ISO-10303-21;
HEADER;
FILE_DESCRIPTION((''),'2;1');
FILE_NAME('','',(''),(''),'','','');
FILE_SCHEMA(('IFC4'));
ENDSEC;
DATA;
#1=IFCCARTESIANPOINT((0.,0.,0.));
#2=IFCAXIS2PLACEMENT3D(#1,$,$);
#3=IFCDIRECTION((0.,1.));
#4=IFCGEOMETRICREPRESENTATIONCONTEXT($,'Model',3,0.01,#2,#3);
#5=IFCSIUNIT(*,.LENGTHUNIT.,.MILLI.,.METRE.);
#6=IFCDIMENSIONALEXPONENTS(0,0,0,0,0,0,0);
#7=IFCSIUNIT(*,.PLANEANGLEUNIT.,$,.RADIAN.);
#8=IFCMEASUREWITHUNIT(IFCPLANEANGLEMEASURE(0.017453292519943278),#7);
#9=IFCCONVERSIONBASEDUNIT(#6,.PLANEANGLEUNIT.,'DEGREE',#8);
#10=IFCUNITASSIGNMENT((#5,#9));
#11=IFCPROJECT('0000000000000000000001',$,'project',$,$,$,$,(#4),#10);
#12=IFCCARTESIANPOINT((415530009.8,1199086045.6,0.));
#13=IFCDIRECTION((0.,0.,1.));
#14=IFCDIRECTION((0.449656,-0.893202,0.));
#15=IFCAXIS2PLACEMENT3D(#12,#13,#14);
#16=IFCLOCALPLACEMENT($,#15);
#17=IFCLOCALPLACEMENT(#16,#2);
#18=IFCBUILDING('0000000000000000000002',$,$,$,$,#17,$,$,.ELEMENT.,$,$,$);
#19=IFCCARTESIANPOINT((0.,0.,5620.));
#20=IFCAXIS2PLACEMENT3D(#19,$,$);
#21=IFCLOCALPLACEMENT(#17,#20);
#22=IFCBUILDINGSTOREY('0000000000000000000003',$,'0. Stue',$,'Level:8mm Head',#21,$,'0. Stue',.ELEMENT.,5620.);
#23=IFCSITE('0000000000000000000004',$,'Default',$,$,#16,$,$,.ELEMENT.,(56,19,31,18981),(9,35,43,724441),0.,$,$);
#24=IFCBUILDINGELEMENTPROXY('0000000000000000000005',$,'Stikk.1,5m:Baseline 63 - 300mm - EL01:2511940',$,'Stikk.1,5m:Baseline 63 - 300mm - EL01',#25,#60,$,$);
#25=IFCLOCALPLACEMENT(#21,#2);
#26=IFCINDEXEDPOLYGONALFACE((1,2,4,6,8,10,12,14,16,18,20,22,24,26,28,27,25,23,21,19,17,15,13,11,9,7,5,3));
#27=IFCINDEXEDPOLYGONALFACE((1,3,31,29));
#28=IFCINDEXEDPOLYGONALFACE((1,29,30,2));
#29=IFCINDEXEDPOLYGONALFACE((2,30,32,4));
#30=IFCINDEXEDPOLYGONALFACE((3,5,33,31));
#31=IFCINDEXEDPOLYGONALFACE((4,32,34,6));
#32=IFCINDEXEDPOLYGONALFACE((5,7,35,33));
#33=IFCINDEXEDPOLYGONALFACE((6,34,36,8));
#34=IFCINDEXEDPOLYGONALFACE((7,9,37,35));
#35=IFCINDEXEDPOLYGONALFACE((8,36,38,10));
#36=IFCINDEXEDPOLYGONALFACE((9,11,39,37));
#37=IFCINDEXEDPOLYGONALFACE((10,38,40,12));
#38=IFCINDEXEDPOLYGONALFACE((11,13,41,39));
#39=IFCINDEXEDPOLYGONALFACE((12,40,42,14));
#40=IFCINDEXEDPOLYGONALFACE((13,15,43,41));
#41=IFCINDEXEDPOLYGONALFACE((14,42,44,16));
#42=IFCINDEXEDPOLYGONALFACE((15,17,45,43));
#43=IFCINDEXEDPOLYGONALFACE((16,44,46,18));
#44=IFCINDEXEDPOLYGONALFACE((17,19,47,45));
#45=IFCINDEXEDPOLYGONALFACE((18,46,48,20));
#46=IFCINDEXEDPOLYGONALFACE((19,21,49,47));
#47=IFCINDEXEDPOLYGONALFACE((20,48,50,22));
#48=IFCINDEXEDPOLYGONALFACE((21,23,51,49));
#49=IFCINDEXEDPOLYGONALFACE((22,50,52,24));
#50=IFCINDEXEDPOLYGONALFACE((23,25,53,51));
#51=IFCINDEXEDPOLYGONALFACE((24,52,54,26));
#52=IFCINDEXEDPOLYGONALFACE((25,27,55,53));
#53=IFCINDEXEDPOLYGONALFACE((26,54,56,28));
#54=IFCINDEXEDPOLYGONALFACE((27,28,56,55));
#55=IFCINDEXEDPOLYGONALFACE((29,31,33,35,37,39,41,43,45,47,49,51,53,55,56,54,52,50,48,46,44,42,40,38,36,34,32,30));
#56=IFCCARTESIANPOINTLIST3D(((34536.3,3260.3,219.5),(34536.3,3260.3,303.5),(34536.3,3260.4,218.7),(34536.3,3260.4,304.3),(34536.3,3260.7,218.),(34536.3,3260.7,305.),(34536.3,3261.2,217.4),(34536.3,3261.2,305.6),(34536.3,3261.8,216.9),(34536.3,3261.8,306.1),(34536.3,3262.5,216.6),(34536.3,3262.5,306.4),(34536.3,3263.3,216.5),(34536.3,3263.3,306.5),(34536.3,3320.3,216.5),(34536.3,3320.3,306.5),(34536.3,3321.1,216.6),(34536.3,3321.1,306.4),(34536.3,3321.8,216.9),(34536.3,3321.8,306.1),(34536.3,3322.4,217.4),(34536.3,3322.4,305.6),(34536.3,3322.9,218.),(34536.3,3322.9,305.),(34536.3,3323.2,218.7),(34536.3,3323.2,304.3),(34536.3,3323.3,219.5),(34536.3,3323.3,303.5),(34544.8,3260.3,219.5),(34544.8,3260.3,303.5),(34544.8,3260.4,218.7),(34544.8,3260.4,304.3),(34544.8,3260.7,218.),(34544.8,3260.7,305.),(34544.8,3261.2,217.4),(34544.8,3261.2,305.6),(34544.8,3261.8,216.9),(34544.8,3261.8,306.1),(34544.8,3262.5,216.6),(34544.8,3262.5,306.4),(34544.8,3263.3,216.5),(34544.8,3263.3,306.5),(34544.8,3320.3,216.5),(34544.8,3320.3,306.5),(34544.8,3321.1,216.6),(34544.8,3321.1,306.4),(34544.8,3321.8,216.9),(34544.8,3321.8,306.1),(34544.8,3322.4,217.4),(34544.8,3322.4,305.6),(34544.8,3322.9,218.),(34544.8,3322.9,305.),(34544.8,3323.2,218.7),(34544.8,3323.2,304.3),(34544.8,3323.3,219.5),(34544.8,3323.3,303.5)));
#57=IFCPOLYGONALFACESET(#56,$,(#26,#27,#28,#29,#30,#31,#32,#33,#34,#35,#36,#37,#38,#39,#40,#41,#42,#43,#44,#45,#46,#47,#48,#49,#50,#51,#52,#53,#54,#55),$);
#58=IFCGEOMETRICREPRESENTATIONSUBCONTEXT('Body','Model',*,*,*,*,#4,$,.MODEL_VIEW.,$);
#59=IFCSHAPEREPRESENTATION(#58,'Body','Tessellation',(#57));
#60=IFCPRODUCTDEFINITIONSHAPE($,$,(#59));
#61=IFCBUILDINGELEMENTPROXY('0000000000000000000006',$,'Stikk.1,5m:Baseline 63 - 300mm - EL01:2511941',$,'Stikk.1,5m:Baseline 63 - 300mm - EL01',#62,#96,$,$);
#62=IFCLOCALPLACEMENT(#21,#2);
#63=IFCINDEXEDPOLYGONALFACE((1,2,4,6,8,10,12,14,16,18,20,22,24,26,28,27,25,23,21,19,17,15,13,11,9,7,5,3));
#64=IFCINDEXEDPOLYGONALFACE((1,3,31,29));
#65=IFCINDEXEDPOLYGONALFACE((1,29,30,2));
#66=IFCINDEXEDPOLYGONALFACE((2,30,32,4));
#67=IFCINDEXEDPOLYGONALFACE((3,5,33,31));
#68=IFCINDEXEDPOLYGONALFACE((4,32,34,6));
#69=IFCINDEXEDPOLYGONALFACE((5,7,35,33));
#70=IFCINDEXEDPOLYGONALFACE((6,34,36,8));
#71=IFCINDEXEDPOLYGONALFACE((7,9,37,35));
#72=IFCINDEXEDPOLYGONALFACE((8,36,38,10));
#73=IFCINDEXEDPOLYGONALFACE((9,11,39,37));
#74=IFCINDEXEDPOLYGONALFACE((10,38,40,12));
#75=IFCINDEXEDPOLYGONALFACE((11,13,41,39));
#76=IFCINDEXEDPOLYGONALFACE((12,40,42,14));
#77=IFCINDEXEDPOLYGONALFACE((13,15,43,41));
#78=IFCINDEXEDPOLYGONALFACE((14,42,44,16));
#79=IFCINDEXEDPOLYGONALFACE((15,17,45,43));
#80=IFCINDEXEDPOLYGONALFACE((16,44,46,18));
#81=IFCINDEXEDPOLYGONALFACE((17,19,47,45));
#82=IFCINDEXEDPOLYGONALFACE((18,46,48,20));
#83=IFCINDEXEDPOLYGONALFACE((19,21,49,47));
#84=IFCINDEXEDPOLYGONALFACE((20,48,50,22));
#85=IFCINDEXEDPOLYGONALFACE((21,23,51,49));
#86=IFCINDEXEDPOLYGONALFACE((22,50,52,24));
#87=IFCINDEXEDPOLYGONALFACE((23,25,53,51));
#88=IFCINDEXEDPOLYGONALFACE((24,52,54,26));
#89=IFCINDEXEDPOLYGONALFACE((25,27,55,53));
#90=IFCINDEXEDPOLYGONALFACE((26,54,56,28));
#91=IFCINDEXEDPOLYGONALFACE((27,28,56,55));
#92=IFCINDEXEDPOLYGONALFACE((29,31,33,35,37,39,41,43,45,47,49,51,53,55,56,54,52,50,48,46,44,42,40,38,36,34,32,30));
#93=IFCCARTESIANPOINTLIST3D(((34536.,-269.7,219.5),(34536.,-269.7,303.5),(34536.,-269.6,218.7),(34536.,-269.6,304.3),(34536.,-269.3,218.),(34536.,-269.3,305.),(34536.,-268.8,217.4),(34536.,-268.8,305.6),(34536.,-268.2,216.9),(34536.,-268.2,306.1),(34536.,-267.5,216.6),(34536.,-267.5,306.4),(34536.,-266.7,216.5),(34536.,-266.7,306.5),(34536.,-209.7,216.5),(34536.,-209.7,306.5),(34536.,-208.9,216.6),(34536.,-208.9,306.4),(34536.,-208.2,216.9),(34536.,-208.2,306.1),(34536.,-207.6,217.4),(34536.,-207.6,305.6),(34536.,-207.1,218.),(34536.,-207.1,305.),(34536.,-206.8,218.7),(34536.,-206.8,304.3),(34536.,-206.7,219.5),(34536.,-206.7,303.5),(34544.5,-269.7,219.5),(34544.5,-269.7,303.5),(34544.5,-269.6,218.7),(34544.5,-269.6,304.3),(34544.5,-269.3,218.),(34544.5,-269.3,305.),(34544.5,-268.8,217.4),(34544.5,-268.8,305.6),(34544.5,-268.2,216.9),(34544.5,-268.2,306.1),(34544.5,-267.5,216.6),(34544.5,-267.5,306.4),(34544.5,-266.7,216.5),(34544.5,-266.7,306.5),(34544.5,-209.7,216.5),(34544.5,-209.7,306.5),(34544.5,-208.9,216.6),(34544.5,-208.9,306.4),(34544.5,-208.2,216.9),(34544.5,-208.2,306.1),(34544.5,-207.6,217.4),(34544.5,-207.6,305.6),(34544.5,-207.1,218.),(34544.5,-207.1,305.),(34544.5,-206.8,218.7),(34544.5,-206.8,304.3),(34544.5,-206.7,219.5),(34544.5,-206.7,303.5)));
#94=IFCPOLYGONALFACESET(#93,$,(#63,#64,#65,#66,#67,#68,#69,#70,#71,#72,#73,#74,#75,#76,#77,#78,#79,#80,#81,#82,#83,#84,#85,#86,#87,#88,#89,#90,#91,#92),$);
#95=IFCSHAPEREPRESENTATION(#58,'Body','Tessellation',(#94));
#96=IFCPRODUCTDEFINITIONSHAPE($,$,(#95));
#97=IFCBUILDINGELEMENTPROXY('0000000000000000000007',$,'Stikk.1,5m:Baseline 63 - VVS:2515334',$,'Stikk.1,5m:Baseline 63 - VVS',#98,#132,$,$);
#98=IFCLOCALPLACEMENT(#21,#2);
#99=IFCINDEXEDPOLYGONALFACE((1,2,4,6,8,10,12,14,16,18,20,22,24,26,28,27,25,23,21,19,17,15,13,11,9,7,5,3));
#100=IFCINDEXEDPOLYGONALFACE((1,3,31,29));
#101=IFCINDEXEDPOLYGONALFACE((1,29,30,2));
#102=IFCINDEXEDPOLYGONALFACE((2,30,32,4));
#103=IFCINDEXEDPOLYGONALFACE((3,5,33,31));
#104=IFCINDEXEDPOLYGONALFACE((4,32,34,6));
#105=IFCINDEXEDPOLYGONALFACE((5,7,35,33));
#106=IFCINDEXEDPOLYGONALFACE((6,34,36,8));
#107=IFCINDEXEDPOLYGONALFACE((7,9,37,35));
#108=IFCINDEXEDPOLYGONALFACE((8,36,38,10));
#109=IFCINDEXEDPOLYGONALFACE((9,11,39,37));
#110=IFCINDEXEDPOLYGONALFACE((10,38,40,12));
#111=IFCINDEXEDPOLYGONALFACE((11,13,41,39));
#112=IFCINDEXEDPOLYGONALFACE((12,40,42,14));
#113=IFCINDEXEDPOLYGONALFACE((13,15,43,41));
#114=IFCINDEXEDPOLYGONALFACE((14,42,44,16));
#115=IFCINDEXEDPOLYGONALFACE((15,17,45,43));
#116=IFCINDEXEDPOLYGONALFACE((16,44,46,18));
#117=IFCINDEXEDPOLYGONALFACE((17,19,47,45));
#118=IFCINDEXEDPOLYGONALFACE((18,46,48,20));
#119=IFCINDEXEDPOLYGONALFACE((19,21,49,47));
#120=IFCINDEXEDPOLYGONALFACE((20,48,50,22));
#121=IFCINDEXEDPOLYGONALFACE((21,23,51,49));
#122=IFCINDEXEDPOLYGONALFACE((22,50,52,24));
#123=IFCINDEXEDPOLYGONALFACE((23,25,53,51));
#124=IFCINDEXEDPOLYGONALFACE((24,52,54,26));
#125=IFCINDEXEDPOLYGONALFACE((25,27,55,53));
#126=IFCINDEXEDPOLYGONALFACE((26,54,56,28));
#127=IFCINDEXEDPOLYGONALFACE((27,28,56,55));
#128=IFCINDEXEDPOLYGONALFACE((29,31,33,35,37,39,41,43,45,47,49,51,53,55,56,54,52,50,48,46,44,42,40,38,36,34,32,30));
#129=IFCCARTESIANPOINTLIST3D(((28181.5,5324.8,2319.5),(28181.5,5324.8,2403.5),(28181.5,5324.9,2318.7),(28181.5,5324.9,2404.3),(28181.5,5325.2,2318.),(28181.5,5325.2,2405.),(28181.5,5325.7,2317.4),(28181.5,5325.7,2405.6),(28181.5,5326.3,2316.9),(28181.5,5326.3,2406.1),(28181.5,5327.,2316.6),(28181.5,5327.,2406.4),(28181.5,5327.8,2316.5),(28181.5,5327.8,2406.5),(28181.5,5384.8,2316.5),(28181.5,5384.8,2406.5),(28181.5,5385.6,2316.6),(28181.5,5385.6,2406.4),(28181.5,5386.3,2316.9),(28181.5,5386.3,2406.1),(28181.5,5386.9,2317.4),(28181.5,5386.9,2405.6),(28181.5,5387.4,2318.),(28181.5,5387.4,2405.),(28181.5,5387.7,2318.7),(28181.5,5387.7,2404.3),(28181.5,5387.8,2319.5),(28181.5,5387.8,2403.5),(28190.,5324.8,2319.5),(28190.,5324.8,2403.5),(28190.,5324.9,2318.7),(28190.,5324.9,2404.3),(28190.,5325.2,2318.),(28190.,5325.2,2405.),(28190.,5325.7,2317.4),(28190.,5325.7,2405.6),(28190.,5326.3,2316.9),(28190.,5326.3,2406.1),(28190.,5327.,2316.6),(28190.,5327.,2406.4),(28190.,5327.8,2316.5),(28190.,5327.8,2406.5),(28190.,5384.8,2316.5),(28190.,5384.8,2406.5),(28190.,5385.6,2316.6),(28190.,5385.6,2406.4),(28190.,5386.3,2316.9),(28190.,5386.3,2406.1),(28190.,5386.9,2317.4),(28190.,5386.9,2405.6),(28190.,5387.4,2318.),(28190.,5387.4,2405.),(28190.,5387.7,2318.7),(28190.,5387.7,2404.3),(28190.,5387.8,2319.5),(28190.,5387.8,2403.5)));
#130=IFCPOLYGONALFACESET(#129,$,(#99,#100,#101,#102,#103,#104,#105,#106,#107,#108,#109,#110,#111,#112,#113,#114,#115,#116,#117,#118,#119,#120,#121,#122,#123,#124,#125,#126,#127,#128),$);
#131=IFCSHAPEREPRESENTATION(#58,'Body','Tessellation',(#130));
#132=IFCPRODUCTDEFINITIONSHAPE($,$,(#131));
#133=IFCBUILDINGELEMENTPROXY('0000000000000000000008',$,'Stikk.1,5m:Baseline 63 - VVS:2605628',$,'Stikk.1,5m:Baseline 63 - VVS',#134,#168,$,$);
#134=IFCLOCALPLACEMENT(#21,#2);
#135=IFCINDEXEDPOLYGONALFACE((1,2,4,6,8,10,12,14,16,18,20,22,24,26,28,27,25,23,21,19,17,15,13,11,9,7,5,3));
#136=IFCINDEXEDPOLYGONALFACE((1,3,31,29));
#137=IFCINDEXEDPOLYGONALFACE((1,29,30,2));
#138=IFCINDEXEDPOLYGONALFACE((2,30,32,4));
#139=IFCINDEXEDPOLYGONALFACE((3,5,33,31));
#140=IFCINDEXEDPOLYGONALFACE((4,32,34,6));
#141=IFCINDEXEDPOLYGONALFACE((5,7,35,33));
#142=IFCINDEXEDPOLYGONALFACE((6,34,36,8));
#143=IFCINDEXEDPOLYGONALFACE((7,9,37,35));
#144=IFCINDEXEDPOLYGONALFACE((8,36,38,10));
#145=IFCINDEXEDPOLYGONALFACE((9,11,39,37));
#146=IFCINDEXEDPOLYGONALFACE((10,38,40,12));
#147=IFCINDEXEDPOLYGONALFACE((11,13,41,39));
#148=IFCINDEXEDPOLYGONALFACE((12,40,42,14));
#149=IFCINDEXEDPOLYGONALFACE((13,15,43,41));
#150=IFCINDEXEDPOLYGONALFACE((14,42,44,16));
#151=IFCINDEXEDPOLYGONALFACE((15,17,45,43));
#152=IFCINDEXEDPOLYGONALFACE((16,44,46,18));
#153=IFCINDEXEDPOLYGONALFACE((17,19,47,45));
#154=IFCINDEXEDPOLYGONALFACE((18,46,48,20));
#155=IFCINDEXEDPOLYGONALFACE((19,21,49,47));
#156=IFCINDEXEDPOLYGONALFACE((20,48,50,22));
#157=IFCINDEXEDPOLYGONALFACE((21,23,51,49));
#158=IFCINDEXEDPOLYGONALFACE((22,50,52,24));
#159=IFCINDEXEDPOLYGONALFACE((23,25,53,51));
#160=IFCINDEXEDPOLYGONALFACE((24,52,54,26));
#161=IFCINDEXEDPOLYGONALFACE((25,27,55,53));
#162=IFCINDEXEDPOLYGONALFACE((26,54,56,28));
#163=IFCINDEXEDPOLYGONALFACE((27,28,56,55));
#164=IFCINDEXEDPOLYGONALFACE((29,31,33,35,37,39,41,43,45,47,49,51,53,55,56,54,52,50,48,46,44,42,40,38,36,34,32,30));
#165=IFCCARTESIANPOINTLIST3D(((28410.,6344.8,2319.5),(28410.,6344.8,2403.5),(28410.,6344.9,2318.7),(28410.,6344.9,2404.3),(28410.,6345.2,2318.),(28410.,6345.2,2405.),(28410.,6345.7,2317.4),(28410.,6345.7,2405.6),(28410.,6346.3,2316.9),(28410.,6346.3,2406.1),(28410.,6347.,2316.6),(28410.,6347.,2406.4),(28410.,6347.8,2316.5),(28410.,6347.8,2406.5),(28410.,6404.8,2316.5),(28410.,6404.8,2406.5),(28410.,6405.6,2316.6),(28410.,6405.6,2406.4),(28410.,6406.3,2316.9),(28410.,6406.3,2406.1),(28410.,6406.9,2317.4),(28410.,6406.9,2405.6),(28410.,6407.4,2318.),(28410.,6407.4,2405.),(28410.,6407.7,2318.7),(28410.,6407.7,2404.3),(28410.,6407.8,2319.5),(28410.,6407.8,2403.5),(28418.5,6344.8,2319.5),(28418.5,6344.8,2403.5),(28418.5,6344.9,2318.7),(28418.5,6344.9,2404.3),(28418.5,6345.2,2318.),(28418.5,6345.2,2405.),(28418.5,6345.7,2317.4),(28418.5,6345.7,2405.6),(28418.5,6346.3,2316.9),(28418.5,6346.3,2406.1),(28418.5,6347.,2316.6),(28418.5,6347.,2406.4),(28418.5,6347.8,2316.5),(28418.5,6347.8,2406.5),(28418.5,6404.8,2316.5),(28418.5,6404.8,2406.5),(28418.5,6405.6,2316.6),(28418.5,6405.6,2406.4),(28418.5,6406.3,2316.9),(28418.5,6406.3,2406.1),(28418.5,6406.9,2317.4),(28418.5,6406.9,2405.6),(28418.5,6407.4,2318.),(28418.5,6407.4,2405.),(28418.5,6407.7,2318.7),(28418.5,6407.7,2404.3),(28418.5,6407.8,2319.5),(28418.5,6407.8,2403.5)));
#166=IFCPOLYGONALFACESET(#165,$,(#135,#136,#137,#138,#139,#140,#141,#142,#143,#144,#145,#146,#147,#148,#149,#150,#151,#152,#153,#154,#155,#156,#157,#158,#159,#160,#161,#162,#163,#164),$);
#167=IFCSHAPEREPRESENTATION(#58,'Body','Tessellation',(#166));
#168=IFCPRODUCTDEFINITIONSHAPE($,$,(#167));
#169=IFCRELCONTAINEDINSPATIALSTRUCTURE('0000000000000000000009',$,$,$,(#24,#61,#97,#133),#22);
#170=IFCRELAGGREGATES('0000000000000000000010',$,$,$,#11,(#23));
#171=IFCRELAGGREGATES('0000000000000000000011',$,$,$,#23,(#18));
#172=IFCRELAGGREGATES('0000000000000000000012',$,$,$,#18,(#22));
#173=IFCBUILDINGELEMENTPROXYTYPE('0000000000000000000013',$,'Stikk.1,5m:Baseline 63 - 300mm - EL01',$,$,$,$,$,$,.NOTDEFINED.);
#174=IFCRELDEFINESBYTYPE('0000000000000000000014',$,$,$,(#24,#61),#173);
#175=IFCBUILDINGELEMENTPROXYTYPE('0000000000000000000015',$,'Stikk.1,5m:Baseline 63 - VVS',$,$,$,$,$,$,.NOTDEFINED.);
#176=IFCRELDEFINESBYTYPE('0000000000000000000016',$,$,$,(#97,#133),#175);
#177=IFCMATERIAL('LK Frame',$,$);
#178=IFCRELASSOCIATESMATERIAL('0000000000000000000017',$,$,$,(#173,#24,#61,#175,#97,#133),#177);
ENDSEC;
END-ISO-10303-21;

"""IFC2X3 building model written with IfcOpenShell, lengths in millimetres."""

from ifc_helpers import new_model, entity, si_unit, converted_unit, direction, frame, frame_2d, origin, place, context, subcontext, project, spatial, polyline, circle_curve, parameter, trimmed, segment, composite_curve, outline, extrude, source, transform, mapped, material, type_object, type_shapes, element, save


model = new_model("IFC2X3")

# Units and contexts
model_context = context("Model", 3, precision=0.01, world=origin(), true_north=direction((0.0, 1.0)))
body_context = subcontext(model_context, "Body", "Model", "MODEL_VIEW")
ifc_project = project(units=[si_unit("LENGTHUNIT", "METRE", prefix="MILLI"), converted_unit("PLANEANGLEUNIT", "DEGREE", entity("IfcPlaneAngleMeasure", 0.017453292519943278), si_unit("PLANEANGLEUNIT", "RADIAN"), dimensions=[0, 0, 0, 0, 0, 0, 0])], contexts=[model_context])

# Site, building, storey
site_placement = place(None, frame((415530009.8, 1199086045.6, 0.0), z_axis=(0.0, 0.0, 1.0), x_axis=(0.449656, -0.893202, 0.0)))
site = spatial("IfcSite", under=ifc_project, at=site_placement, Name="Default", CompositionType="ELEMENT", RefLatitude=(56, 19, 31, 18981), RefLongitude=(9, 35, 43, 724441), RefElevation=0.0)
building_placement = place(site_placement, origin())
building = spatial("IfcBuilding", under=site, at=building_placement, CompositionType="ELEMENT")
storey_placement = place(building_placement, frame((0.0, 0.0, 5620.0)))
storey = spatial("IfcBuildingStorey", under=building, at=storey_placement, Name="0. Stue", ObjectType="Level:8mm Head", LongName="0. Stue", CompositionType="ELEMENT", Elevation=5620.0)

# Building element proxies
ifc_material_1 = material(Name="LK Frame")
building_element_proxy_type_1 = type_object("IfcBuildingElementProxyType", Name="Stikk.1,5m:Baseline 63 - 300mm - EL01", PredefinedType="NOTDEFINED", material=ifc_material_1)
shared_shape_1 = source(origin(), body_context, "Body", "SweptSolid", [
    extrude(outline(composite_curve([segment(trimmed(circle_curve(frame_2d((-42.0, 28.5), x_axis=(1.0, 0.0)), 3.0), [parameter(90.0)], [parameter(180.0)], True, "PARAMETER"), True, "CONTINUOUS"), segment(polyline([(-45.0, 28.5), (-45.0, -28.5)]), True, "CONTINUOUS"), segment(trimmed(circle_curve(frame_2d((-42.0, -28.5), x_axis=(1.0, 0.0)), 3.0), [parameter(180.0)], [parameter(270.0)], True, "PARAMETER"), True, "CONTINUOUS"), segment(polyline([(-42.0, -31.5), (42.0, -31.5)]), True, "CONTINUOUS"), segment(trimmed(circle_curve(frame_2d((42.0, -28.5), x_axis=(-1.0, 0.0)), 3.0), [parameter(90.0)], [parameter(180.0)], True, "PARAMETER"), True, "CONTINUOUS"), segment(polyline([(45.0, -28.5), (45.0, 28.5)]), True, "CONTINUOUS"), segment(trimmed(circle_curve(frame_2d((42.0, 28.5), x_axis=(-1.0, 0.0)), 3.0), [parameter(180.0)], [parameter(270.0)], True, "PARAMETER"), True, "CONTINUOUS"), segment(polyline([(42.0, 31.5), (-42.0, 31.5)]), True, "CONTINUOUS")], self_intersect=False)), frame((0.0, 38.5, 0.0), z_axis=(0.0, 0.0, 1.0), x_axis=(0.0, -1.0, 0.0)), (0.0, 0.0, 1.0), 8.5),
])
type_shapes(building_element_proxy_type_1, [shared_shape_1])
for number, where, z_axis, x_axis, name in (
    (1, (34536.3, 3291.8, 300.0), (1.0, 0.0, 0.0), (0.0, -1.0, 0.0), "Stikk.1,5m:Baseline 63 - 300mm - EL01:2511940"),
    (2, (34536.0, -238.2, 300.0), (1.0, 0.0, 0.0), (0.0, -1.0, 0.0), "Stikk.1,5m:Baseline 63 - 300mm - EL01:2511941"),
):
    element("IfcBuildingElementProxy", number, at=place(storey_placement, frame(where, z_axis=z_axis, x_axis=x_axis)), inside=storey, type_object=building_element_proxy_type_1, material=ifc_material_1, Name=name, ObjectType="Stikk.1,5m:Baseline 63 - 300mm - EL01", context=body_context, shape_type="MappedRepresentation", body=[
        mapped(shared_shape_1, transform((0.0, 0.0, 0.0), scale=1.0)),
    ])
building_element_proxy_type_2 = type_object("IfcBuildingElementProxyType", Name="Stikk.1,5m:Baseline 63 - VVS", PredefinedType="NOTDEFINED", material=ifc_material_1)
shared_shape_2 = source(origin(), body_context, "Body", "SweptSolid", [
    extrude(outline(composite_curve([segment(polyline([(-42.0, -31.5), (42.0, -31.5)]), True, "CONTINUOUS"), segment(trimmed(circle_curve(frame_2d((42.0, -28.5), x_axis=(-1.0, 0.0)), 3.0), [parameter(90.0)], [parameter(180.0)], True, "PARAMETER"), True, "CONTINUOUS"), segment(polyline([(45.0, -28.5), (45.0, 28.5)]), True, "CONTINUOUS"), segment(trimmed(circle_curve(frame_2d((42.0, 28.5), x_axis=(-1.0, 0.0)), 3.0), [parameter(180.0)], [parameter(270.0)], True, "PARAMETER"), True, "CONTINUOUS"), segment(polyline([(42.0, 31.5), (-42.0, 31.5)]), True, "CONTINUOUS"), segment(trimmed(circle_curve(frame_2d((-42.0, 28.5), x_axis=(1.0, 0.0)), 3.0), [parameter(90.0)], [parameter(180.0)], True, "PARAMETER"), True, "CONTINUOUS"), segment(polyline([(-45.0, 28.5), (-45.0, -28.5)]), True, "CONTINUOUS"), segment(trimmed(circle_curve(frame_2d((-42.0, -28.5), x_axis=(1.0, 0.0)), 3.0), [parameter(180.0)], [parameter(270.0)], True, "PARAMETER"), True, "CONTINUOUS")], self_intersect=False)), frame((0.0, -38.5, 0.0), z_axis=(0.0, 0.0, 1.0), x_axis=(0.0, 1.0, 0.0)), (0.0, 0.0, 1.0), 8.5),
])
type_shapes(building_element_proxy_type_2, [shared_shape_2])
for number, where, z_axis, x_axis, name in (
    (3, (28190.0, 5356.3, 2400.0), (-1.0, 0.0, 0.0), (0.0, -1.0, 0.0), "Stikk.1,5m:Baseline 63 - VVS:2515334"),
    (4, (28410.0, 6376.3, 2400.0), (1.0, 0.0, 0.0), (0.0, 1.0, 0.0), "Stikk.1,5m:Baseline 63 - VVS:2605628"),
):
    element("IfcBuildingElementProxy", number, at=place(storey_placement, frame(where, z_axis=z_axis, x_axis=x_axis)), inside=storey, type_object=building_element_proxy_type_2, material=ifc_material_1, Name=name, ObjectType="Stikk.1,5m:Baseline 63 - VVS", context=body_context, shape_type="MappedRepresentation", body=[
        mapped(shared_shape_2, transform((0.0, 0.0, 0.0), scale=1.0)),
    ])

save(model, "model.ifc")
